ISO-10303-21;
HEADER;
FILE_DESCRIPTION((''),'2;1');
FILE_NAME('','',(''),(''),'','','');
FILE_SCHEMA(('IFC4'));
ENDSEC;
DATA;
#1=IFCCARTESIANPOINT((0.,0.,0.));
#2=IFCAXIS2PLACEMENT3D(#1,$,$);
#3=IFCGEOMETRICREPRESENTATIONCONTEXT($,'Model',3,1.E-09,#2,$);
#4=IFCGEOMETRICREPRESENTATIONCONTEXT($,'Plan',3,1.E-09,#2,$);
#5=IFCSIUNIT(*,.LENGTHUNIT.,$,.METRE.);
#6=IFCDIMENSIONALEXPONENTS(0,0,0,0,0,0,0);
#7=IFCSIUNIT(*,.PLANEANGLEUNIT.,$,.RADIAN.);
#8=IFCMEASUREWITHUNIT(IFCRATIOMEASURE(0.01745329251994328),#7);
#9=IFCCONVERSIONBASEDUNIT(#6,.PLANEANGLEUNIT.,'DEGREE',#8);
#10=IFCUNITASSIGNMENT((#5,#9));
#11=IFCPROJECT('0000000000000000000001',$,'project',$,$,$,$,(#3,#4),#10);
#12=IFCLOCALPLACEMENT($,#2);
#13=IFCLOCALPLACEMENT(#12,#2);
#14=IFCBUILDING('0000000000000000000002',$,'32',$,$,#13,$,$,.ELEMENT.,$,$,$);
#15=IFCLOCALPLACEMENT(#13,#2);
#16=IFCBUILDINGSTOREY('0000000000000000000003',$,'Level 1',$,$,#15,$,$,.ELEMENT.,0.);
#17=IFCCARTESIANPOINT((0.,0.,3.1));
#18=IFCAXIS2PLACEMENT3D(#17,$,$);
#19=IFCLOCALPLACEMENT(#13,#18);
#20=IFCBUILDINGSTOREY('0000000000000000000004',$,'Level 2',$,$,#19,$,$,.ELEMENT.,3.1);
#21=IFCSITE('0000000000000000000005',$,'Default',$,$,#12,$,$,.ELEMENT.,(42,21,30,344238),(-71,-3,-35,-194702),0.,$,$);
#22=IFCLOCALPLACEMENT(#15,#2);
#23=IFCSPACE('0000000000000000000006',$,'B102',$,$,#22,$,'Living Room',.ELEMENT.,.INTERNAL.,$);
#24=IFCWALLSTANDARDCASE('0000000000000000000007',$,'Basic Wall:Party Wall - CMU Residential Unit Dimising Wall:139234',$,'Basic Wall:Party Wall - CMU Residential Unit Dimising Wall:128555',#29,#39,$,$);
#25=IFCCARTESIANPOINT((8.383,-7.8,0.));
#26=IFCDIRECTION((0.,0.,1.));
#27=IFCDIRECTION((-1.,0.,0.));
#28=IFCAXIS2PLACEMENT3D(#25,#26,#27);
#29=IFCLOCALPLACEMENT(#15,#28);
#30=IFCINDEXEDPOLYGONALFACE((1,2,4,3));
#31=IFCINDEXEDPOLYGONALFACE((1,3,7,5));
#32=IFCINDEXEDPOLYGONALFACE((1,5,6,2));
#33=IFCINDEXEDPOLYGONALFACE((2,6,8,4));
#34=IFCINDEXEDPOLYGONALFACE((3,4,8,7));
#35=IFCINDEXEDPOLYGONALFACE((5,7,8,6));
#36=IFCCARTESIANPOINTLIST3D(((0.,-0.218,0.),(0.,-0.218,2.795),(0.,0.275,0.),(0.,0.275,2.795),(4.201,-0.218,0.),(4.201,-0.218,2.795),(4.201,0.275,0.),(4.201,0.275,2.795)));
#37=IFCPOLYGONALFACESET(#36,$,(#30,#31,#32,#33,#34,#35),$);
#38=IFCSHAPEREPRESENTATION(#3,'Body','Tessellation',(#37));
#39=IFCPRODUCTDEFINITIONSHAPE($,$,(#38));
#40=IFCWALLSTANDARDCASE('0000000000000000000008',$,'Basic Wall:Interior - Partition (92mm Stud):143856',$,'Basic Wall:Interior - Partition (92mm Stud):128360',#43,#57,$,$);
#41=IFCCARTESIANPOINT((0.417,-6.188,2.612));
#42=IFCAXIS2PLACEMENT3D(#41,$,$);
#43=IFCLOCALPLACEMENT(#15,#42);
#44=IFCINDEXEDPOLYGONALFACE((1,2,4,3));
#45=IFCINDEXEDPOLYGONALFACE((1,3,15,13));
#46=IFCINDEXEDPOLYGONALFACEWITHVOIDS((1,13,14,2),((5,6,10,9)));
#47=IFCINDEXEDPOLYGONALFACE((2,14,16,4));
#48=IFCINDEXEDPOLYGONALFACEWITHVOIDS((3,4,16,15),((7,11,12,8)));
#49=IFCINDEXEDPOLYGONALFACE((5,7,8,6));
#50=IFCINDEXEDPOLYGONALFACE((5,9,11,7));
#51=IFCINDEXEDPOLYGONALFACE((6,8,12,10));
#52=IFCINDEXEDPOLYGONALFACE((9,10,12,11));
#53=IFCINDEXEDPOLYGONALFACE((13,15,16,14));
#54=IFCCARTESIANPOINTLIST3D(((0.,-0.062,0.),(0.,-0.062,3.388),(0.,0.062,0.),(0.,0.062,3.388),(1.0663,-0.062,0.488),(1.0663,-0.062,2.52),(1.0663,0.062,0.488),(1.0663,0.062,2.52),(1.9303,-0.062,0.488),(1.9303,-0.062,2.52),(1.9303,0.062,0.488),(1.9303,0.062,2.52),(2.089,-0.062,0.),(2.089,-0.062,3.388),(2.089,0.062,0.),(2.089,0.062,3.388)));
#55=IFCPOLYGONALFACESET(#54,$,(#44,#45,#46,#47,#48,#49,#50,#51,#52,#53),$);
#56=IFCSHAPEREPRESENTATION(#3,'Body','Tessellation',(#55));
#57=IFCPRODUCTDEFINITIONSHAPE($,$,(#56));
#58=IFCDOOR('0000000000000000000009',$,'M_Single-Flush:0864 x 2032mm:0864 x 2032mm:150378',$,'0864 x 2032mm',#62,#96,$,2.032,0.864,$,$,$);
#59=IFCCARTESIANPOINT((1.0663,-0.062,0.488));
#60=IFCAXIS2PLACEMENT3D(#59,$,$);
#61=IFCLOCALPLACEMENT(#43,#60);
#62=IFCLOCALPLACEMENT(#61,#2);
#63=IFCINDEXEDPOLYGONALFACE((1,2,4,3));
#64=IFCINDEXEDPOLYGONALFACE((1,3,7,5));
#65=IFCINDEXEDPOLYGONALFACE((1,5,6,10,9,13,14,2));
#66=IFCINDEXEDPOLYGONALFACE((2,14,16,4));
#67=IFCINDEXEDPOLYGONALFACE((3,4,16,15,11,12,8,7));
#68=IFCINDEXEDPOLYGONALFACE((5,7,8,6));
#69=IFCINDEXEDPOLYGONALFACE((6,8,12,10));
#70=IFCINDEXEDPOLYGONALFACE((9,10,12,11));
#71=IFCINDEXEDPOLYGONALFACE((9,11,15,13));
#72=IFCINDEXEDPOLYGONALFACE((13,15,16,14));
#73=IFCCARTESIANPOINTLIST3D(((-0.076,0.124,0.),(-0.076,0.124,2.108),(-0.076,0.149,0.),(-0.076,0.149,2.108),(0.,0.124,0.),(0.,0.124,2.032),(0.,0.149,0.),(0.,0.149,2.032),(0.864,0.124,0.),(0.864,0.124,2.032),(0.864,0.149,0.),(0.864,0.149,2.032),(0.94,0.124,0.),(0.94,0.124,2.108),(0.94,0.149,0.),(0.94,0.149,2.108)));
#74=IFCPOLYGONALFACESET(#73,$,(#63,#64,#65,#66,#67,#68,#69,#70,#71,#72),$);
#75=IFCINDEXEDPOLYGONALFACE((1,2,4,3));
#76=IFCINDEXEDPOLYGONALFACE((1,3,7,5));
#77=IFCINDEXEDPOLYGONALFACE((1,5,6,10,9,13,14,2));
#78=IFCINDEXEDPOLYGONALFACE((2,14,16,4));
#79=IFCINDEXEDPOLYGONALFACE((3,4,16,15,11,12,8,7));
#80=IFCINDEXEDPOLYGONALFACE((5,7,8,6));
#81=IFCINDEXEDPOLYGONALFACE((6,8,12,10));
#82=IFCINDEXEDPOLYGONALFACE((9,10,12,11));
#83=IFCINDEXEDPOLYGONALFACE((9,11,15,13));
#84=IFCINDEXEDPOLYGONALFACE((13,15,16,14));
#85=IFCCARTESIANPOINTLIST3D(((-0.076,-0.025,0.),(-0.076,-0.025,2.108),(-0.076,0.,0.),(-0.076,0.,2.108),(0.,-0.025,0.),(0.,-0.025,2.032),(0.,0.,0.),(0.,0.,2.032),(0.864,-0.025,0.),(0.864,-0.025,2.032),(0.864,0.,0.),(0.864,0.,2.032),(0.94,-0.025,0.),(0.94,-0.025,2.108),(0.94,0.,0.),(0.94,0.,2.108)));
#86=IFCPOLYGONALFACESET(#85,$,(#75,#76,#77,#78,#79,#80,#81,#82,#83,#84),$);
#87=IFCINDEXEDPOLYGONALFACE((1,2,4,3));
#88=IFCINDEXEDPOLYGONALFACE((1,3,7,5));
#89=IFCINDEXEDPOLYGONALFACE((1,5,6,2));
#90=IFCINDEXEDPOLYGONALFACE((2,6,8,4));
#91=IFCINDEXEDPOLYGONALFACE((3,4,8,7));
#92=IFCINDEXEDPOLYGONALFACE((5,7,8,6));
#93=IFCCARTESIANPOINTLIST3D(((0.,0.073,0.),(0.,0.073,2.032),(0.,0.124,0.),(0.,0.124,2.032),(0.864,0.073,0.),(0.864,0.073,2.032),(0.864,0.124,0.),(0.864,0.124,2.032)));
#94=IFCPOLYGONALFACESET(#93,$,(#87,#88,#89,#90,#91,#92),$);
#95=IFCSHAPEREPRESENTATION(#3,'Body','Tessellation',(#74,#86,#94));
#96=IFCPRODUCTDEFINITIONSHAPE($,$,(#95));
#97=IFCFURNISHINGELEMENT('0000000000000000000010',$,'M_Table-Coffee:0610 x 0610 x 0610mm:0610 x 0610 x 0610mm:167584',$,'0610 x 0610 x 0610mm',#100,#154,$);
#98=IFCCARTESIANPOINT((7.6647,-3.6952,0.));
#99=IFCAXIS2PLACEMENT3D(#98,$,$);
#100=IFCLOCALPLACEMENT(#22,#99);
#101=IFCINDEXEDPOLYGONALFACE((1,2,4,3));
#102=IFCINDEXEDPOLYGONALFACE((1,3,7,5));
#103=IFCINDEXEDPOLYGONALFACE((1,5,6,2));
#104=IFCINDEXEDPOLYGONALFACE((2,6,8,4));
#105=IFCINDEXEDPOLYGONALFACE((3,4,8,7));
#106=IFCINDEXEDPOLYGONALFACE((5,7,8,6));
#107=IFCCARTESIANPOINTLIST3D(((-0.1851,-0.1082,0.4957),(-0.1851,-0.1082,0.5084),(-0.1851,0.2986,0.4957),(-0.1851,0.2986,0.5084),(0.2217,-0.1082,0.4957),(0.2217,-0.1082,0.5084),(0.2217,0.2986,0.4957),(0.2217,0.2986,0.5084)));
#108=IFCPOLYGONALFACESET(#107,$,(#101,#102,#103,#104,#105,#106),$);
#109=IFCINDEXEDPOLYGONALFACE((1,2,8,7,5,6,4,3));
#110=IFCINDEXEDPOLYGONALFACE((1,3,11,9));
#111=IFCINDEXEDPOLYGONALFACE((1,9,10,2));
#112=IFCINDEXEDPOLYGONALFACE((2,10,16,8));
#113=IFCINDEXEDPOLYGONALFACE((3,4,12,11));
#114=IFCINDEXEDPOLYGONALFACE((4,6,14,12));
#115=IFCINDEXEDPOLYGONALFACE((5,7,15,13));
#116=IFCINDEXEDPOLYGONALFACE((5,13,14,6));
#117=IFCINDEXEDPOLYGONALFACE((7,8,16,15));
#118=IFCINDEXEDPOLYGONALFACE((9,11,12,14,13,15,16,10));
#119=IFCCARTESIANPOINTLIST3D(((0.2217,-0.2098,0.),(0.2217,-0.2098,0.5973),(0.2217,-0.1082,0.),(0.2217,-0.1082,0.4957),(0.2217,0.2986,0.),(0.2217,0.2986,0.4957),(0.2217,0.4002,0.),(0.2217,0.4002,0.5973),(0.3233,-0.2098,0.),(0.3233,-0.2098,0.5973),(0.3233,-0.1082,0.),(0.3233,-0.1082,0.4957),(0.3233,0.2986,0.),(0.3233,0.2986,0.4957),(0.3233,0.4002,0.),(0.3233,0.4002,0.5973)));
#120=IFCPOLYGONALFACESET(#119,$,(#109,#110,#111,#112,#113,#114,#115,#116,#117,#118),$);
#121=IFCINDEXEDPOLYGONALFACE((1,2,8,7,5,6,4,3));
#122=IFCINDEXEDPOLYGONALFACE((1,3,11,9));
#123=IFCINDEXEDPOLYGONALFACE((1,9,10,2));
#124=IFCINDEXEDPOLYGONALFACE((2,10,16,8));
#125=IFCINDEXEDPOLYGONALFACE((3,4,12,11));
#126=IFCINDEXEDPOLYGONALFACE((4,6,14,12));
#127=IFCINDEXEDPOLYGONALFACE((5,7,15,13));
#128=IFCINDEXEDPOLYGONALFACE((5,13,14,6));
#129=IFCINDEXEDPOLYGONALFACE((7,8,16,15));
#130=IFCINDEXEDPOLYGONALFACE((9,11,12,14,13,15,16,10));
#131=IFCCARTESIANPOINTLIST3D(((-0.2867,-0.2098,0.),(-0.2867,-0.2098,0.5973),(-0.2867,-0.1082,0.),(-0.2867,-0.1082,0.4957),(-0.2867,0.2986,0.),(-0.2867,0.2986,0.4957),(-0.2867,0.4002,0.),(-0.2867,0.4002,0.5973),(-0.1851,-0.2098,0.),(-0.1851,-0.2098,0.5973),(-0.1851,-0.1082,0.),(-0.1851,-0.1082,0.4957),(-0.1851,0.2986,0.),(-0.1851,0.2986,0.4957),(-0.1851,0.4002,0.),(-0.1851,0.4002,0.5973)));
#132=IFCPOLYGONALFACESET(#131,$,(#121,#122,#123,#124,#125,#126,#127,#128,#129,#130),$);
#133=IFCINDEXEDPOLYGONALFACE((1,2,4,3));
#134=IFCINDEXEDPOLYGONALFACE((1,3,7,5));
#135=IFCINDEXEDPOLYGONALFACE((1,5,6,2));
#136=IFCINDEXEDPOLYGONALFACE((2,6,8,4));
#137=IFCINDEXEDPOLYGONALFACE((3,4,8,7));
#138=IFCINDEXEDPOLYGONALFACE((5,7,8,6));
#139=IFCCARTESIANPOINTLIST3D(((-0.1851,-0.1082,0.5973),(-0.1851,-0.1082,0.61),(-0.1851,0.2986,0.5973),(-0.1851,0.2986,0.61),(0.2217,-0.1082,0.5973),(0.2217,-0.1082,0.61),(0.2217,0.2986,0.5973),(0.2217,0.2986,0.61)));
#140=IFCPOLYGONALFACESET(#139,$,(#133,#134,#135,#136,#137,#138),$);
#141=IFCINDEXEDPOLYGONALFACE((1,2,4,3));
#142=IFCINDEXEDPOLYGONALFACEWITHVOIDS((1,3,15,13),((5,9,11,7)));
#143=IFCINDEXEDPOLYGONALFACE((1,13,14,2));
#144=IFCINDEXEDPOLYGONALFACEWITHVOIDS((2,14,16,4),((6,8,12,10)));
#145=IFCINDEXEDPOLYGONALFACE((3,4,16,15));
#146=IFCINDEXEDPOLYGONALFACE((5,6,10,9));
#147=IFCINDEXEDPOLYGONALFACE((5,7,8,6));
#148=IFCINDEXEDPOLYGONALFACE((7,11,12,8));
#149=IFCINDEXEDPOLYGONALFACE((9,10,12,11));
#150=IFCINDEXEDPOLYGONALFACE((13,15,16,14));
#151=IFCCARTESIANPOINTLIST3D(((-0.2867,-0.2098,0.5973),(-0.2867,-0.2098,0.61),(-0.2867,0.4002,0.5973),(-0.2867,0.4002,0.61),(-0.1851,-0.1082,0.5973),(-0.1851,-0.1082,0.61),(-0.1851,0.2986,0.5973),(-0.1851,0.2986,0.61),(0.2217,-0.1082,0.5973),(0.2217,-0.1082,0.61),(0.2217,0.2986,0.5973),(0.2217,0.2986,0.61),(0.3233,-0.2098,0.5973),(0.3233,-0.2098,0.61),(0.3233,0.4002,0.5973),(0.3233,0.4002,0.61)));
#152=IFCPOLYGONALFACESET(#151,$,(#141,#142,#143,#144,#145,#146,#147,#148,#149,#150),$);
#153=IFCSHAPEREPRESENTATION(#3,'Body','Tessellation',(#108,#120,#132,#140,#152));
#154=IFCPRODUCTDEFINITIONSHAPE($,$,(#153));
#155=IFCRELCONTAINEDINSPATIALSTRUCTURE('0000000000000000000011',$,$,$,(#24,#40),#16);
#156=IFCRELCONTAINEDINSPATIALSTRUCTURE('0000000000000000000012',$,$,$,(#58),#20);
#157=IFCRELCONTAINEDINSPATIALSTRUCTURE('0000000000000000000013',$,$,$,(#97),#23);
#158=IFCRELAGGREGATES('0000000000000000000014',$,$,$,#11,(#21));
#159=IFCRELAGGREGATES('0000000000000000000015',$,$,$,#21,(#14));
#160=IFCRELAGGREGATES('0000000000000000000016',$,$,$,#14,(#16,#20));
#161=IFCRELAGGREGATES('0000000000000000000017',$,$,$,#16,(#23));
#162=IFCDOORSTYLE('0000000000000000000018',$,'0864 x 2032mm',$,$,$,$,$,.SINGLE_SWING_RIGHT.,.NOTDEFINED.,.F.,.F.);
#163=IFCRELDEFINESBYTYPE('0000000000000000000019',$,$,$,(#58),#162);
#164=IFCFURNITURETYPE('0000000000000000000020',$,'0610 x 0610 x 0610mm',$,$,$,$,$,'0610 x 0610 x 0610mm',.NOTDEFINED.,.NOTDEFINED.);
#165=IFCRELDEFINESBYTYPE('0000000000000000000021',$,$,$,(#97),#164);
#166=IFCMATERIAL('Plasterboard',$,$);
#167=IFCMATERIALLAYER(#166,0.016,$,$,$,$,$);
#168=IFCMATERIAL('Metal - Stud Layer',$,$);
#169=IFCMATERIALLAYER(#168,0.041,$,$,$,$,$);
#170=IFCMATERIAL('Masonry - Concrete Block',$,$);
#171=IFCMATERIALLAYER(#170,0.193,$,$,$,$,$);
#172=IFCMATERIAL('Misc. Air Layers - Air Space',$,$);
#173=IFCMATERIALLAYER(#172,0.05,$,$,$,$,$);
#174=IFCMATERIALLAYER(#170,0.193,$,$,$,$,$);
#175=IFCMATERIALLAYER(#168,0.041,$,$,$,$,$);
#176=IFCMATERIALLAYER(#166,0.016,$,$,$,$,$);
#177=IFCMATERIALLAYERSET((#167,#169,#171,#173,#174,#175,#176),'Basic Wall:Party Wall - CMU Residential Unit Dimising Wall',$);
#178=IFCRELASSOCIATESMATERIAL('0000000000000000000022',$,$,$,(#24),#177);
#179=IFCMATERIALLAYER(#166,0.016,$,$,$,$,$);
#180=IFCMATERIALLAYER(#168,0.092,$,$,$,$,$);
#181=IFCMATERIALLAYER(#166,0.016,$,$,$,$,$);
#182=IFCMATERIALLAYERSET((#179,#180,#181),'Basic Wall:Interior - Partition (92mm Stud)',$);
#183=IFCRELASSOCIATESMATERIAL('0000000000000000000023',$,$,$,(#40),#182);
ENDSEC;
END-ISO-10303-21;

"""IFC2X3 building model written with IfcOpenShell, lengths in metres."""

from ifc_helpers import new_model, entity, si_unit, converted_unit, frame, frame_2d, origin, origin_2d_with_axis, place, context, project, spatial, polyline, rectangle, outline, extrude, clip, bounded_halfspace, source, transform, mapped, material, layer, layer_set, layer_usage, type_object, type_shapes, element, fill, save


model = new_model("IFC2X3")

# Units and contexts
model_context = context("Model", 3, precision=1e-09, world=origin())
plan_context = context("Plan", 3, precision=1e-09, world=origin())
ifc_project = project(units=[si_unit("LENGTHUNIT", "METRE"), converted_unit("PLANEANGLEUNIT", "DEGREE", entity("IfcRatioMeasure", 0.01745329251994328), si_unit("PLANEANGLEUNIT", "RADIAN"), dimensions=[0, 0, 0, 0, 0, 0, 0])], contexts=[model_context, plan_context])

# Site, building, storey
site_placement = place(None, origin())
site = spatial("IfcSite", under=ifc_project, at=site_placement, Name="Default", CompositionType="ELEMENT", RefLatitude=(42, 21, 30, 344238), RefLongitude=(-71, -3, -35, -194702), RefElevation=0.0)
building_placement = place(site_placement, origin())
building = spatial("IfcBuilding", under=site, at=building_placement, Name="32", CompositionType="ELEMENT")
storey_1_placement = place(building_placement, origin())
storey_1 = spatial("IfcBuildingStorey", under=building, at=storey_1_placement, Name="Level 1", CompositionType="ELEMENT", Elevation=0.0)

# Shared definitions
ifc_material_1 = material(Name="Misc. Air Layers - Air Space")
ifc_material_2 = material(Name="Masonry - Concrete Block")
ifc_material_3 = material(Name="Metal - Stud Layer")
ifc_material_4 = material(Name="Plasterboard")

# Shared definitions
ifc_layer_1 = layer(ifc_material_4, 0.016)
ifc_layer_2 = layer(ifc_material_3, 0.092)
ifc_layer_3 = layer(ifc_material_4, 0.016)
ifc_layer_set_1 = layer_set([ifc_layer_1, ifc_layer_2, ifc_layer_3], Name="Basic Wall:Interior - Partition (92mm Stud)")

# Wall
ifc_layer_4 = layer(ifc_material_4, 0.016)
ifc_layer_5 = layer(ifc_material_3, 0.041)
ifc_layer_6 = layer(ifc_material_2, 0.193)
ifc_layer_7 = layer(ifc_material_1, 0.05)
ifc_layer_8 = layer(ifc_material_2, 0.193)
ifc_layer_9 = layer(ifc_material_3, 0.041)
ifc_layer_10 = layer(ifc_material_4, 0.016)
ifc_layer_set_2 = layer_set([ifc_layer_4, ifc_layer_5, ifc_layer_6, ifc_layer_7, ifc_layer_8, ifc_layer_9, ifc_layer_10], Name="Basic Wall:Party Wall - CMU Residential Unit Dimising Wall")
ifc_layer_usage_1 = layer_usage(ifc_layer_set_2, "AXIS2", "NEGATIVE", 0.275)
wall_1_placement = place(storey_1_placement, frame((8.383, -7.8, 0.0), z_axis=(0.0, 0.0, 1.0), x_axis=(-1.0, 0.0, 0.0)))
element("IfcWallStandardCase", 1, at=wall_1_placement, inside=storey_1, material=ifc_layer_usage_1, Name="Basic Wall:Party Wall - CMU Residential Unit Dimising Wall:139234", ObjectType="Basic Wall:Party Wall - CMU Residential Unit Dimising Wall:128555", context=model_context, shape_type="Clipping", body=[
    clip(clip(extrude(rectangle(XDim=4.201, YDim=0.55, at=frame_2d((2.1005, 0.0), x_axis=(-1.0, 0.0))), origin(), (0.0, 0.0, 1.0), 2.795), bounded_halfspace(frame((0.0, -0.218, 2.795), z_axis=(0.0, 1.0, 0.0), x_axis=(-1.0, 0.0, 0.0)), True, frame((0.0, -0.218, 2.795), z_axis=(0.0, 1.0, 0.0), x_axis=(-1.0, 0.0, 0.0)), polyline([(0.0, 0.0), (-3.708, 0.0), (-4.201, 0.0), (-4.201, -2.795), (0.0, -2.795), (0.0, 0.0)]))), bounded_halfspace(frame((4.201, 0.275, 0.0), z_axis=(-1.0, 0.0, 0.0), x_axis=(0.0, -1.0, 0.0)), True, frame((4.201, 0.275, 0.0), z_axis=(-1.0, 0.0, 0.0), x_axis=(0.0, -1.0, 0.0)), polyline([(0.0, 0.0), (0.493, 0.0), (0.493, 2.795), (0.0, 2.795), (0.0, 0.0)]))),
])

# Wall, opening
ifc_layer_usage_2 = layer_usage(ifc_layer_set_1, "AXIS2", "NEGATIVE", 0.062)
wall_2_placement = place(storey_1_placement, frame((0.417, -6.188, 2.612)))
wall_2 = element("IfcWallStandardCase", 2, at=wall_2_placement, inside=storey_1, material=ifc_layer_usage_2, Name="Basic Wall:Interior - Partition (92mm Stud):143856", ObjectType="Basic Wall:Interior - Partition (92mm Stud):128360", context=model_context, shape_type="SweptSolid", body=[
    extrude(rectangle(XDim=2.089, YDim=0.124, at=frame_2d((1.0445, 0.0), x_axis=(-1.0, 0.0))), origin(), (0.0, 0.0, 1.0), 3.388),
])
opening_1_placement = place(wall_2_placement, frame((1.0663, -0.062, 0.488)))
opening_1 = element("IfcOpeningElement", 3, at=opening_1_placement, cuts=wall_2, ObjectType="Opening", context=model_context, shape_type="SweptSolid", body=[
    extrude(rectangle(XDim=0.864, YDim=2.032, at=frame_2d((1.016, 0.432), x_axis=(0.0, 1.0))), frame((0.0, 0.0, 0.0), z_axis=(0.0, 1.0, 0.0), x_axis=(0.0, 0.0, 1.0)), (0.0, 0.0, 1.0), 0.124),
])

# Shared definitions
storey_2_placement = place(building_placement, frame((0.0, 0.0, 3.1)))
storey_2 = spatial("IfcBuildingStorey", under=building, at=storey_2_placement, Name="Level 2", CompositionType="ELEMENT", Elevation=3.1)

# Door
door_style_1 = type_object("IfcDoorStyle", Name="0864 x 2032mm", ConstructionType="NOTDEFINED", OperationType="SINGLE_SWING_RIGHT", ParameterTakesPrecedence=False, Sizeable=False)
shared_shape_1 = source(origin(), model_context, "Body", "SweptSolid", [
    extrude(outline(polyline([(-0.508, -1.073), (0.508, -1.073), (0.508, 1.035), (0.432, 1.035), (0.432, -0.997), (-0.432, -0.997), (-0.432, 1.035), (-0.508, 1.035), (-0.508, -1.073)])), frame((0.432, 0.124, 1.035), z_axis=(0.0, 1.0, 0.0), x_axis=(1.0, 0.0, 0.0)), (0.0, 0.0, 1.0), 0.025),
    extrude(outline(polyline([(-1.073, -0.508), (1.035, -0.508), (1.035, -0.432), (-0.997, -0.432), (-0.997, 0.432), (1.035, 0.432), (1.035, 0.508), (-1.073, 0.508), (-1.073, -0.508)])), frame((0.432, -0.025, 1.035), z_axis=(0.0, 1.0, 0.0), x_axis=(0.0, 0.0, -1.0)), (0.0, 0.0, 1.0), 0.025),
    extrude(rectangle(XDim=0.051, YDim=0.864, at=origin_2d_with_axis()), frame((0.432, 0.0985, 0.0), z_axis=(0.0, 0.0, 1.0), x_axis=(0.0, 1.0, 0.0)), (0.0, 0.0, 1.0), 2.032),
])
type_shapes(door_style_1, [shared_shape_1])
door_1_placement = place(opening_1_placement, origin())
door_1 = element("IfcDoor", 4, at=door_1_placement, inside=storey_2, type_object=door_style_1, Name="M_Single-Flush:0864 x 2032mm:0864 x 2032mm:150378", ObjectType="0864 x 2032mm", OverallHeight=2.032, OverallWidth=0.864, context=model_context, shape_type="MappedRepresentation", body=[
    mapped(shared_shape_1, transform((0.0, 0.0, 0.0), scale=1.0)),
])
fill(opening_1, door_1)

# Shared definitions
space_1_placement = place(storey_1_placement, origin())
space_1 = spatial("IfcSpace", under=storey_1, at=space_1_placement, Name="B102", LongName="Living Room", CompositionType="ELEMENT", InteriorOrExteriorSpace="INTERNAL")

# Furnishing element
furniture_type_1 = type_object("IfcFurnitureType", Name="0610 x 0610 x 0610mm", ElementType="0610 x 0610 x 0610mm", AssemblyPlace="NOTDEFINED")
shared_shape_2 = source(origin(), model_context, "Body", "SweptSolid", [
    extrude(rectangle(XDim=0.4068, YDim=0.4068, at=origin_2d_with_axis()), frame((0.0183, 0.0952, 0.4957), z_axis=(0.0, 0.0, 1.0), x_axis=(-1.0, 0.0, 0.0)), (0.0, 0.0, 1.0), 0.0127),
    extrude(outline(polyline([(-0.2732, -0.305), (0.324, -0.305), (0.324, 0.305), (-0.2732, 0.305), (-0.2732, 0.2034), (0.2225, 0.2034), (0.2225, -0.2034), (-0.2732, -0.2034), (-0.2732, -0.305)])), frame((0.2217, 0.0952, 0.2732), z_axis=(1.0, 0.0, 0.0), x_axis=(0.0, 0.0, 1.0)), (0.0, 0.0, 1.0), 0.1016),
    extrude(outline(polyline([(-0.305, -0.3241), (0.305, -0.3241), (0.305, 0.2733), (0.2034, 0.2733), (0.2034, -0.2224), (-0.2034, -0.2224), (-0.2034, 0.2733), (-0.305, 0.2733), (-0.305, -0.3241)])), frame((-0.2867, 0.0952, 0.2733), z_axis=(1.0, 0.0, 0.0), x_axis=(0.0, -1.0, 0.0)), (0.0, 0.0, 1.0), 0.1016),
    extrude(rectangle(XDim=0.4068, YDim=0.4068, at=origin_2d_with_axis()), frame((0.0183, 0.0952, 0.5973), z_axis=(0.0, 0.0, 1.0), x_axis=(-1.0, 0.0, 0.0)), (0.0, 0.0, 1.0), 0.0127),
    extrude(outline(polyline([(-0.305, -0.305), (0.305, -0.305), (0.305, 0.305), (-0.305, 0.305), (-0.305, -0.305)]), holes=[polyline([(-0.2034, -0.2034), (-0.2034, 0.2034), (0.2034, 0.2034), (0.2034, -0.2034), (-0.2034, -0.2034)])]), frame((0.0183, 0.0952, 0.5973), z_axis=(0.0, 0.0, 1.0), x_axis=(-1.0, 0.0, 0.0)), (0.0, 0.0, 1.0), 0.0127),
])
type_shapes(furniture_type_1, [shared_shape_2])
for number, where, name in (
    (5, (7.6647, -3.6952, 0.0), "M_Table-Coffee:0610 x 0610 x 0610mm:0610 x 0610 x 0610mm:167584"),
):
    element("IfcFurnishingElement", number, at=place(space_1_placement, frame(where)), inside=space_1, type_object=furniture_type_1, Name=name, ObjectType="0610 x 0610 x 0610mm", context=model_context, shape_type="MappedRepresentation", body=[
        mapped(shared_shape_2, transform((0.0, 0.0, 0.0), scale=1.0)),
    ])

save(model, "model.ifc")
